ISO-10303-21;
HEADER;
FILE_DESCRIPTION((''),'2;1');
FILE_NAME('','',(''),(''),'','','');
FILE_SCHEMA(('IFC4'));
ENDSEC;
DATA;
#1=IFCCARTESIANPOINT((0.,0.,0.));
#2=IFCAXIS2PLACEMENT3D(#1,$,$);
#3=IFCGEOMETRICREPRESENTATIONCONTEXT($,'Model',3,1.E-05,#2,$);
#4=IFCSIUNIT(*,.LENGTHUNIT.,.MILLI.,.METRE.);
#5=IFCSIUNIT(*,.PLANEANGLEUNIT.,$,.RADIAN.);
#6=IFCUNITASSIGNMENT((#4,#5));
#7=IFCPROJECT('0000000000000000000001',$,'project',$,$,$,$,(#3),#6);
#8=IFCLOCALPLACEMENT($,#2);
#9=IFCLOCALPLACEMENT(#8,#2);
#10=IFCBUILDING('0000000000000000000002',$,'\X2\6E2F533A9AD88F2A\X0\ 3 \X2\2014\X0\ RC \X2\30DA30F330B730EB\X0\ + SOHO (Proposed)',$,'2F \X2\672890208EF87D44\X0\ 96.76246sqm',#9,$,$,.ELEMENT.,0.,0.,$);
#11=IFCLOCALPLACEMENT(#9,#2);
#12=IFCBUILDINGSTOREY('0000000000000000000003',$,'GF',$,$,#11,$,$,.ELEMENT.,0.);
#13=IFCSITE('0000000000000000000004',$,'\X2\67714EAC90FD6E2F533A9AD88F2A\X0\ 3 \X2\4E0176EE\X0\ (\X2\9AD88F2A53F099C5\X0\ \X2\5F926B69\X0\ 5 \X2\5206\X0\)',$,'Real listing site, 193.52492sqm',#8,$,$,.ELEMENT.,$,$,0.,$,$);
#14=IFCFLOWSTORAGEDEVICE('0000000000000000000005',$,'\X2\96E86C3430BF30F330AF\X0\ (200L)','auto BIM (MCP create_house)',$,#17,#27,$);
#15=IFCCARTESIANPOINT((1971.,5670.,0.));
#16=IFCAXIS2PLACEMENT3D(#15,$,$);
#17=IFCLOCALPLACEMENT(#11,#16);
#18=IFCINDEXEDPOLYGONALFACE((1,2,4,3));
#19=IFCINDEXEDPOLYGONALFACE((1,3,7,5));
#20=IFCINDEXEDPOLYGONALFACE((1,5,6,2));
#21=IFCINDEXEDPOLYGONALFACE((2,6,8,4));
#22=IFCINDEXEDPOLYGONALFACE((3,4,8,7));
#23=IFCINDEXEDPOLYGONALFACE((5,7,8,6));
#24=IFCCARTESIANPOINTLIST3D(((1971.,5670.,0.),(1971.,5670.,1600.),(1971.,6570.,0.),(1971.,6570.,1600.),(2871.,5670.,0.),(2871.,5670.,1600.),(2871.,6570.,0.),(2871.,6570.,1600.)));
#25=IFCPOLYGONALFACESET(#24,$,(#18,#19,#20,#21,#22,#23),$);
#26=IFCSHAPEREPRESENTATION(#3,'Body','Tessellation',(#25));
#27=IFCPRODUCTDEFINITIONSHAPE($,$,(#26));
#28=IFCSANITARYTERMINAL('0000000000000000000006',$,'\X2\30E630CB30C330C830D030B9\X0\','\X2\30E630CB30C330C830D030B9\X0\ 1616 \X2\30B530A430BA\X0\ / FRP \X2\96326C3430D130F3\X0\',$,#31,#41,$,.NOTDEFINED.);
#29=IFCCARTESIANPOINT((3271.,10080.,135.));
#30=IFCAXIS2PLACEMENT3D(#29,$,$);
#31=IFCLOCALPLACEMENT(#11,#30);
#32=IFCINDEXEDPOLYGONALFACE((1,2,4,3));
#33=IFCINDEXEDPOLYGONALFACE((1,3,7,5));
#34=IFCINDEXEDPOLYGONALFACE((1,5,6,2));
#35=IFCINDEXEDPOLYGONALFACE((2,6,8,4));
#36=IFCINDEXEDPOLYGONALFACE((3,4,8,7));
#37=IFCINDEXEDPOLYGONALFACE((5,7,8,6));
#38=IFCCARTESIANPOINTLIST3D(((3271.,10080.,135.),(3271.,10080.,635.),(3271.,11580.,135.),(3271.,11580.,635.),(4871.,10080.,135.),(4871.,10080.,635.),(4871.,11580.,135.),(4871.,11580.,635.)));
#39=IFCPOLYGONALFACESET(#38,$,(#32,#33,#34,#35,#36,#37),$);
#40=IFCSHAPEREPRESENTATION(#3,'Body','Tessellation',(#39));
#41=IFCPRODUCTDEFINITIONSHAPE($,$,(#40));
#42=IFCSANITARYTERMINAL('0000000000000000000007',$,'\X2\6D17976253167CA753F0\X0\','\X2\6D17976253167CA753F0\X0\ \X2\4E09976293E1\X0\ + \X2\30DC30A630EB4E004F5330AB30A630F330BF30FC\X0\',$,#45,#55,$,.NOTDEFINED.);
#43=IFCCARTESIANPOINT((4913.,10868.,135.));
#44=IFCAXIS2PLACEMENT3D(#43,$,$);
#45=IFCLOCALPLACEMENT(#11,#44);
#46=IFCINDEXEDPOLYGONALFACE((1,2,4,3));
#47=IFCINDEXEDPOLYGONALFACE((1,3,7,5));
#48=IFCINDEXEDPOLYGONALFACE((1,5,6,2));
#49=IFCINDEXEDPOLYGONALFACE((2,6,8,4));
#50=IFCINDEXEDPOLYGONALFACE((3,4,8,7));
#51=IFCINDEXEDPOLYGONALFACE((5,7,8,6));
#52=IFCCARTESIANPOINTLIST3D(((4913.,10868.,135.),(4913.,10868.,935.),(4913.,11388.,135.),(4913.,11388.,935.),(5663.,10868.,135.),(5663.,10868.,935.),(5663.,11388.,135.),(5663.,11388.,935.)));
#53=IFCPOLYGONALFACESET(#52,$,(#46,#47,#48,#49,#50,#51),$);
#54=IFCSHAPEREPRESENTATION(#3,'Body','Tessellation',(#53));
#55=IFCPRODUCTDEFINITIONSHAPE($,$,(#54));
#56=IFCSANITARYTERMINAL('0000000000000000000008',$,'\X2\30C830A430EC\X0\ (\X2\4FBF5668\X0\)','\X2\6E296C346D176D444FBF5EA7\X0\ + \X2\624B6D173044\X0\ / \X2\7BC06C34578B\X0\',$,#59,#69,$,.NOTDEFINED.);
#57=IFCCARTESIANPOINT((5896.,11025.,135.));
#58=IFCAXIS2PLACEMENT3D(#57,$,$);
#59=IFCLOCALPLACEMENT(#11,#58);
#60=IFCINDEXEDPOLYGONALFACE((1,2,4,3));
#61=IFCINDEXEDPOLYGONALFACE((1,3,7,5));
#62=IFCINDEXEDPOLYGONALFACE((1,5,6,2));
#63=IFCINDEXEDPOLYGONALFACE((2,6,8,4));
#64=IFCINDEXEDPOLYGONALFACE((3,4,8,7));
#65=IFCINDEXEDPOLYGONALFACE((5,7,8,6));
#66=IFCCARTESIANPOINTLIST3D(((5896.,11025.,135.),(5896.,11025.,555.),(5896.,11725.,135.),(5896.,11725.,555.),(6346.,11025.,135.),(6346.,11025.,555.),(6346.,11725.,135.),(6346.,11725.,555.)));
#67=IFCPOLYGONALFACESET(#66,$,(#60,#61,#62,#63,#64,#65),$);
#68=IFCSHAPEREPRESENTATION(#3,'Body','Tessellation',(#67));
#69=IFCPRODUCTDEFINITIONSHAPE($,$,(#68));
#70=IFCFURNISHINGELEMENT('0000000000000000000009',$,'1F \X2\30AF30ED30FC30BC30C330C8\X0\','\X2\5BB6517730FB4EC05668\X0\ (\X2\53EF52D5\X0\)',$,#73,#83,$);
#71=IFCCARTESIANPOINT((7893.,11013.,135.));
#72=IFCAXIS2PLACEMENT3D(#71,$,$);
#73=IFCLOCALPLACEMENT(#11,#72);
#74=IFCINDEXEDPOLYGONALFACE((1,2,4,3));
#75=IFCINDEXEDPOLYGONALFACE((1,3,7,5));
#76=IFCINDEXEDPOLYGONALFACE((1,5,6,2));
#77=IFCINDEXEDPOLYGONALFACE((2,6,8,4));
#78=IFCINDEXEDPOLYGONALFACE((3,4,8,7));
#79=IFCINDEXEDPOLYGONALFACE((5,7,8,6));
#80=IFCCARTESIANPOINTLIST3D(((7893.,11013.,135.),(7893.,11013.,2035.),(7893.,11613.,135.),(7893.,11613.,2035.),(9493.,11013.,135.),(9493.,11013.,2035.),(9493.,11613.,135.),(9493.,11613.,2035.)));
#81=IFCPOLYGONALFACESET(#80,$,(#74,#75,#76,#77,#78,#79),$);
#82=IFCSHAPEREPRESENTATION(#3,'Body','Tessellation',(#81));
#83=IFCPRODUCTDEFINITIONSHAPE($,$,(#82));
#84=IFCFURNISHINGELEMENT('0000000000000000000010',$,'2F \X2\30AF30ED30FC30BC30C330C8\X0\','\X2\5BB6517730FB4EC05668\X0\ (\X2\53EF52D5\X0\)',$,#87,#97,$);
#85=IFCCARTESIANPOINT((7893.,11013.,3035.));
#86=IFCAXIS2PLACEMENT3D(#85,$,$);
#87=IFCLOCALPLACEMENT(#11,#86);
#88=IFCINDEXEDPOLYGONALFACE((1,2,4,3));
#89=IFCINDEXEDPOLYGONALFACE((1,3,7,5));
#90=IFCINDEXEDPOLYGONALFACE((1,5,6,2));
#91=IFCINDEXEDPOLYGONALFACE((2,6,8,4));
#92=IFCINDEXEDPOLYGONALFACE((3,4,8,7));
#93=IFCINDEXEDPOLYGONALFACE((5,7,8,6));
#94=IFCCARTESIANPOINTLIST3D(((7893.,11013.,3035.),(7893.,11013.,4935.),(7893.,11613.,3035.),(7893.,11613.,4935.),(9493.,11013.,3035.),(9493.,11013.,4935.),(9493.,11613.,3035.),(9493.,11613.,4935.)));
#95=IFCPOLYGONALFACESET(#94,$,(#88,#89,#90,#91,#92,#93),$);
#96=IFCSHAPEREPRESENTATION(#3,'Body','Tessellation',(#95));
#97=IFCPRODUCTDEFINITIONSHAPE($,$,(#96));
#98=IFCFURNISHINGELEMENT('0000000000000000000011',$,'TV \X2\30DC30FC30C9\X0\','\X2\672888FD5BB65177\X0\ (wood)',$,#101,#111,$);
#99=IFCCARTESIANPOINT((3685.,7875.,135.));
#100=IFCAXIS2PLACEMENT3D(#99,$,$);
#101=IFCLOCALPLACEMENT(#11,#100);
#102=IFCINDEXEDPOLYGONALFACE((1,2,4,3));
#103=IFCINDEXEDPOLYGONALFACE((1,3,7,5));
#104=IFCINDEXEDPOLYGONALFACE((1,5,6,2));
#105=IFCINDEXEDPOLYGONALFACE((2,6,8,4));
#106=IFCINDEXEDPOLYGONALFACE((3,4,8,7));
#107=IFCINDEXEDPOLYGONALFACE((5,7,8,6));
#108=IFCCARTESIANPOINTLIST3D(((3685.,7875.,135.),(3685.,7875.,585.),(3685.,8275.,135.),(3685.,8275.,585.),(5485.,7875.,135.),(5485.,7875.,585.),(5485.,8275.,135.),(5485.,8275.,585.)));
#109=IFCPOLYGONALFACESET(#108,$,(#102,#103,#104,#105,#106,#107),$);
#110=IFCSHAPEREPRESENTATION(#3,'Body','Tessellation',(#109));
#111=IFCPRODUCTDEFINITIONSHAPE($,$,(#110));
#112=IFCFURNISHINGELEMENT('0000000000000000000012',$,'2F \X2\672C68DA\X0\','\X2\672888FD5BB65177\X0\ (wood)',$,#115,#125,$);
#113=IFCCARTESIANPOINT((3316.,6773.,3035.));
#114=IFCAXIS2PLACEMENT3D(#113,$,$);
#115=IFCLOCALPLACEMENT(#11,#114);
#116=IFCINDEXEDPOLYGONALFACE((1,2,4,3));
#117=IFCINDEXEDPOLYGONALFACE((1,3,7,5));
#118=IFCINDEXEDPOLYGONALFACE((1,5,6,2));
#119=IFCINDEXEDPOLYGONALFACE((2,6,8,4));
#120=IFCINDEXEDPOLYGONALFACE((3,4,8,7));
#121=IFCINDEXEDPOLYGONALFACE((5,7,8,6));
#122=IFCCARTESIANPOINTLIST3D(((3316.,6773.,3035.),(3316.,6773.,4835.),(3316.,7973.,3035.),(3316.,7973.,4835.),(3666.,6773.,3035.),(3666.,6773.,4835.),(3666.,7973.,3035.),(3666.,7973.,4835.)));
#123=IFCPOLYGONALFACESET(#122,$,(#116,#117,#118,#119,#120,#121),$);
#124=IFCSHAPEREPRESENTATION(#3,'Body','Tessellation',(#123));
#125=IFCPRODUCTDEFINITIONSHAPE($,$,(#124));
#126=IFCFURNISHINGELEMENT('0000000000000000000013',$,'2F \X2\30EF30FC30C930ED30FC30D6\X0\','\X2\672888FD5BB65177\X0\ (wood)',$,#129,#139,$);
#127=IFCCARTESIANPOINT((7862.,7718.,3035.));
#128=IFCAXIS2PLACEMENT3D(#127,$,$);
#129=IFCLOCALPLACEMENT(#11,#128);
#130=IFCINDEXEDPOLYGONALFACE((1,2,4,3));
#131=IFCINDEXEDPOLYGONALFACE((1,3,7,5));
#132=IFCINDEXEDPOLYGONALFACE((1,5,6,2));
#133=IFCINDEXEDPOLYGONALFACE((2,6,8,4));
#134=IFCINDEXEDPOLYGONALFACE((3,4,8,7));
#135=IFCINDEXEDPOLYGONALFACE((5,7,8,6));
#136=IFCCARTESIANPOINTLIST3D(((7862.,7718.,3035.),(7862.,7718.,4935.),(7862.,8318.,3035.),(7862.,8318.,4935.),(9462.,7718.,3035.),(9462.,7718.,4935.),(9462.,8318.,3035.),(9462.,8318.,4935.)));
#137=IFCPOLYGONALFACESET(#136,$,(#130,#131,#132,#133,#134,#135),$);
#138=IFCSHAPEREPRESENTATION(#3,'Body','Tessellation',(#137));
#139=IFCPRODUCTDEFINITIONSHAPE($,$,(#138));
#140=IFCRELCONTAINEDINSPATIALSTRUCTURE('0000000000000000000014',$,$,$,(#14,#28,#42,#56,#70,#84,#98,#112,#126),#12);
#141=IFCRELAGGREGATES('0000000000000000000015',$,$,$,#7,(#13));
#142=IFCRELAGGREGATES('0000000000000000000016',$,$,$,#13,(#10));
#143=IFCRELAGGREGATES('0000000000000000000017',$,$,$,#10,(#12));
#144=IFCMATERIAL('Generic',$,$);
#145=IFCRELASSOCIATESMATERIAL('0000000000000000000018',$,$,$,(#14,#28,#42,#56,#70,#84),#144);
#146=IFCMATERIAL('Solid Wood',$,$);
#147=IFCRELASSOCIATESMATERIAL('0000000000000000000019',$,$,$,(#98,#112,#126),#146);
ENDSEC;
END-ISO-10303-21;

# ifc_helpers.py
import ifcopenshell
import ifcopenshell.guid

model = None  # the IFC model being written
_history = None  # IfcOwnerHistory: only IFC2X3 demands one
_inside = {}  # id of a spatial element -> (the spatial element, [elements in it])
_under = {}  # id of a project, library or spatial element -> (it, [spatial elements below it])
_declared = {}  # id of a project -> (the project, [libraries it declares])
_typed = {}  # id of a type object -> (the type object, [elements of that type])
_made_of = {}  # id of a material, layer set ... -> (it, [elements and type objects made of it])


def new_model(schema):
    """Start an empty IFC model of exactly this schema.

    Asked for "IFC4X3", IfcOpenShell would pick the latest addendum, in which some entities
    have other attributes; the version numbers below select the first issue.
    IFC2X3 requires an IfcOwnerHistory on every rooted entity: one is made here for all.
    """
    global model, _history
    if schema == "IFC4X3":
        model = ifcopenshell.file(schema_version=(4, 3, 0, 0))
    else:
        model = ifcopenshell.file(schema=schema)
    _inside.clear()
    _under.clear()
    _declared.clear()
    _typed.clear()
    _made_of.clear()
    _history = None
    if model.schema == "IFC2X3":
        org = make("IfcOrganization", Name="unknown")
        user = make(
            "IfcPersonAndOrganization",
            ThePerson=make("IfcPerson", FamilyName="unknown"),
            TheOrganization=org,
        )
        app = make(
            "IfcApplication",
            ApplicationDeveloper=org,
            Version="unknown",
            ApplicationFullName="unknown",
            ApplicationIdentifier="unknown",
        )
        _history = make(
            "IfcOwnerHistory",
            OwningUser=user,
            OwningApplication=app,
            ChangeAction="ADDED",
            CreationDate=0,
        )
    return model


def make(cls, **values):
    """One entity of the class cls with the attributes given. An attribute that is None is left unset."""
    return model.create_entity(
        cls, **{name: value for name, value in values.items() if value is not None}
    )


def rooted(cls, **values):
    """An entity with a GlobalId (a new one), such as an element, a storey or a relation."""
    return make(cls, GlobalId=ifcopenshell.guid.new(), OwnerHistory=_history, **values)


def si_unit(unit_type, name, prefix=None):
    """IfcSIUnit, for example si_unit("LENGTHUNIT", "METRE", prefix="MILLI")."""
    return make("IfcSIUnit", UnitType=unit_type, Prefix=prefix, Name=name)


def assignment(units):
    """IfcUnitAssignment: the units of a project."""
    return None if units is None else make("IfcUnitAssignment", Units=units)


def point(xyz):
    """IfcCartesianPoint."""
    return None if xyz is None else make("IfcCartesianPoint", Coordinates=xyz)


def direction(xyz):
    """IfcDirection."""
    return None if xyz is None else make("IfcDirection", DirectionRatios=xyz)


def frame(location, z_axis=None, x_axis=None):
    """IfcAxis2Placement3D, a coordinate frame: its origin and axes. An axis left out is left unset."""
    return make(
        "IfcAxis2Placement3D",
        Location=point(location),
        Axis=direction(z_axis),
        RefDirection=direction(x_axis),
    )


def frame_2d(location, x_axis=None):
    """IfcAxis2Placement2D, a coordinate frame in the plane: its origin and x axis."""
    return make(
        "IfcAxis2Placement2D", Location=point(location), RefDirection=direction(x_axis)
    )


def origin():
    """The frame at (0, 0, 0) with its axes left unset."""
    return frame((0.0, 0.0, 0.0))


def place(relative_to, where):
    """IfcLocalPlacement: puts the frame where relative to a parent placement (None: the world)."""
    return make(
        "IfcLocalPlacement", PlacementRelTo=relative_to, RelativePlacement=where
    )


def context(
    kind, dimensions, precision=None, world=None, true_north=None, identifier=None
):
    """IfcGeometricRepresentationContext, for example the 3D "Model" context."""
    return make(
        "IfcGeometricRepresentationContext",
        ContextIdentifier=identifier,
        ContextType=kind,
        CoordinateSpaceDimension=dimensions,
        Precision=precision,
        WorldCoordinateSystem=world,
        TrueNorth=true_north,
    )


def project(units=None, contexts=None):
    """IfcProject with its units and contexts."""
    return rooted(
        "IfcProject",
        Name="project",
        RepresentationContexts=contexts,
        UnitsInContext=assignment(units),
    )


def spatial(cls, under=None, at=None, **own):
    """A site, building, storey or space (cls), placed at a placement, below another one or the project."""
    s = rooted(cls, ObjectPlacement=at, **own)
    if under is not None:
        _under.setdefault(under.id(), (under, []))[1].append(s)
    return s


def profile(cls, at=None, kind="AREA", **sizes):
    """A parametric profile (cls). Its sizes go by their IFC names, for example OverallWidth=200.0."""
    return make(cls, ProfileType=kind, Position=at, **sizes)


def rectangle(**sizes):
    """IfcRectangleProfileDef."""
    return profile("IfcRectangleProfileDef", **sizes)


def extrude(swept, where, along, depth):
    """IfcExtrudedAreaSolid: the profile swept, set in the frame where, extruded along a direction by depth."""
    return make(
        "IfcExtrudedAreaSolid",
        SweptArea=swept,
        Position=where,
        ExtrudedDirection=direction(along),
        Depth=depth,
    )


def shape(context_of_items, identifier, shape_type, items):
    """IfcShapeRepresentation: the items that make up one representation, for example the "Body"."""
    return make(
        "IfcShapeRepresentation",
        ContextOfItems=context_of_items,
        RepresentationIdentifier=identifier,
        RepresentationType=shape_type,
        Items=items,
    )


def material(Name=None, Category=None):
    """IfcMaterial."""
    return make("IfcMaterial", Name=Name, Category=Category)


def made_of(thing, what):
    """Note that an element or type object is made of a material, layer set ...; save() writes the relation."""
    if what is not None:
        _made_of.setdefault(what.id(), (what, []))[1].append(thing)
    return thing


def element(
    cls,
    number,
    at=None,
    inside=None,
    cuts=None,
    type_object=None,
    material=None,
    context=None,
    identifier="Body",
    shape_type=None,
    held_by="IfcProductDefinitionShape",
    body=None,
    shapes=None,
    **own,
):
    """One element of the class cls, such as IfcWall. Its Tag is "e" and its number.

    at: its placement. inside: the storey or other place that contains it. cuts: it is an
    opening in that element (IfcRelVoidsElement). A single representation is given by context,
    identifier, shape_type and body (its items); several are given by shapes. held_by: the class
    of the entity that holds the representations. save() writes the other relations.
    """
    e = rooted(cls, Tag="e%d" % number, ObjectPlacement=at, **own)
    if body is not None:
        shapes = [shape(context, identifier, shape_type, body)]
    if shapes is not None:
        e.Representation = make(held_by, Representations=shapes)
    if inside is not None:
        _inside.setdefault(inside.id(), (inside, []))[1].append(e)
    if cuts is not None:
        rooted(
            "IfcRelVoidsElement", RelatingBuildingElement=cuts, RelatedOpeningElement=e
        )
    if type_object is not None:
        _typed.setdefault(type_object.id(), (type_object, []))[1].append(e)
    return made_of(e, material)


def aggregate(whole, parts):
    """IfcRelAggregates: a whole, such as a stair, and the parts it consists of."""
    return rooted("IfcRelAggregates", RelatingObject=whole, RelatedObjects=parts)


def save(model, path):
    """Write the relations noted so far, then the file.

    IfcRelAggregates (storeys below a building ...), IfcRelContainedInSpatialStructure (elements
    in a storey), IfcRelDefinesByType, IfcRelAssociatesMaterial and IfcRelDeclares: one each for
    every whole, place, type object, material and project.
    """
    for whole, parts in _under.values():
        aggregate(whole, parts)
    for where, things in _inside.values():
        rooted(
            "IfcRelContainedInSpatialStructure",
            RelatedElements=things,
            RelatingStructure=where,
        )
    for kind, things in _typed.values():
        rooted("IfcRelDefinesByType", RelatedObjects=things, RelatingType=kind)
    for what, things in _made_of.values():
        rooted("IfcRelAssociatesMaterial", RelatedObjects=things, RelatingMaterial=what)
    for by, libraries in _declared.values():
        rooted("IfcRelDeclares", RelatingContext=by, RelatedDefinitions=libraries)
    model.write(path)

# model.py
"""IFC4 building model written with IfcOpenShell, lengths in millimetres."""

from ifc_helpers import new_model, si_unit, frame, frame_2d, origin, place, context, project, spatial, rectangle, extrude, material, element, save


model = new_model("IFC4")

# Units and contexts
model_context = context("Model", 3, precision=1e-05, world=origin())
ifc_project = project(units=[si_unit("LENGTHUNIT", "METRE", prefix="MILLI"), si_unit("PLANEANGLEUNIT", "RADIAN")], contexts=[model_context])

# Site, building, storey
site_placement = place(None, origin())
site = spatial("IfcSite", under=ifc_project, at=site_placement, Name="東京都港区高輪 3 丁目 (高輪台駅 徒歩 5 分)", ObjectType="Real listing site, 193.52492sqm", CompositionType="ELEMENT", RefElevation=0.0)
building_placement = place(site_placement, origin())
building = spatial("IfcBuilding", under=site, at=building_placement, Name="港区高輪 3 — RC ペンシル + SOHO (Proposed)", ObjectType="2F 木造軸組 96.76246sqm", CompositionType="ELEMENT", ElevationOfRefHeight=0.0, ElevationOfTerrain=0.0)
storey_placement = place(building_placement, origin())
storey = spatial("IfcBuildingStorey", under=building, at=storey_placement, Name="GF", CompositionType="ELEMENT", Elevation=0.0)

# Shared definitions
ifc_material_1 = material(Name="Solid Wood")

# Flow storage device
ifc_material_2 = material(Name="Generic")
flow_storage_device_placement = place(storey_placement, frame((1971.0, 5670.0, 0.0)))
element("IfcFlowStorageDevice", 1, at=flow_storage_device_placement, inside=storey, material=ifc_material_2, Name="雨水タンク (200L)", Description="auto BIM (MCP create_house)", context=model_context, shape_type="SweptSolid", body=[
    extrude(rectangle(XDim=900.0, YDim=900.0, at=frame_2d((450.0, 450.0))), frame((1971.0, 5670.0, 0.0)), (0.0, 0.0, 1.0), 1600.0),
])

# Sanitary terminals
sanitary_terminal_1_placement = place(storey_placement, frame((3271.0, 10080.0, 135.0)))
element("IfcSanitaryTerminal", 2, at=sanitary_terminal_1_placement, inside=storey, material=ifc_material_2, Name="ユニットバス", Description="ユニットバス 1616 サイズ / FRP 防水パン", PredefinedType="NOTDEFINED", context=model_context, shape_type="SweptSolid", body=[
    extrude(rectangle(XDim=1600.0, YDim=1500.0, at=frame_2d((800.0, 750.0))), frame((3271.0, 10080.0, 135.0)), (0.0, 0.0, 1.0), 500.0),
])
sanitary_terminal_2_placement = place(storey_placement, frame((4913.0, 10868.0, 135.0)))
element("IfcSanitaryTerminal", 3, at=sanitary_terminal_2_placement, inside=storey, material=ifc_material_2, Name="洗面化粧台", Description="洗面化粧台 三面鏡 + ボウル一体カウンター", PredefinedType="NOTDEFINED", context=model_context, shape_type="SweptSolid", body=[
    extrude(rectangle(XDim=750.0, YDim=520.0, at=frame_2d((375.0, 260.0))), frame((4913.0, 10868.0, 135.0)), (0.0, 0.0, 1.0), 800.0),
])
sanitary_terminal_3_placement = place(storey_placement, frame((5896.0, 11025.0, 135.0)))
element("IfcSanitaryTerminal", 4, at=sanitary_terminal_3_placement, inside=storey, material=ifc_material_2, Name="トイレ (便器)", Description="温水洗浄便座 + 手洗い / 節水型", PredefinedType="NOTDEFINED", context=model_context, shape_type="SweptSolid", body=[
    extrude(rectangle(XDim=450.0, YDim=700.0, at=frame_2d((225.0, 350.0))), frame((5896.0, 11025.0, 135.0)), (0.0, 0.0, 1.0), 420.0),
])

# Furnishing elements
furnishing_1_placement = place(storey_placement, frame((7893.0, 11013.0, 135.0)))
element("IfcFurnishingElement", 5, at=furnishing_1_placement, inside=storey, material=ifc_material_2, Name="1F クローゼット", Description="家具・什器 (可動)", context=model_context, shape_type="SweptSolid", body=[
    extrude(rectangle(XDim=1600.0, YDim=600.0, at=frame_2d((800.0, 300.0))), frame((7893.0, 11013.0, 135.0)), (0.0, 0.0, 1.0), 1900.0),
])
furnishing_2_placement = place(storey_placement, frame((7893.0, 11013.0, 3035.0)))
element("IfcFurnishingElement", 6, at=furnishing_2_placement, inside=storey, material=ifc_material_2, Name="2F クローゼット", Description="家具・什器 (可動)", context=model_context, shape_type="SweptSolid", body=[
    extrude(rectangle(XDim=1600.0, YDim=600.0, at=frame_2d((800.0, 300.0))), frame((7893.0, 11013.0, 3035.0)), (0.0, 0.0, 1.0), 1900.0),
])
furnishing_3_placement = place(storey_placement, frame((3685.0, 7875.0, 135.0)))
element("IfcFurnishingElement", 7, at=furnishing_3_placement, inside=storey, material=ifc_material_1, Name="TV ボード", Description="木製家具 (wood)", context=model_context, shape_type="SweptSolid", body=[
    extrude(rectangle(XDim=1800.0, YDim=400.0, at=frame_2d((900.0, 200.0))), frame((3685.0, 7875.0, 135.0)), (0.0, 0.0, 1.0), 450.0),
])
furnishing_4_placement = place(storey_placement, frame((3316.0, 6773.0, 3035.0)))
element("IfcFurnishingElement", 8, at=furnishing_4_placement, inside=storey, material=ifc_material_1, Name="2F 本棚", Description="木製家具 (wood)", context=model_context, shape_type="SweptSolid", body=[
    extrude(rectangle(XDim=350.0, YDim=1200.0, at=frame_2d((175.0, 600.0))), frame((3316.0, 6773.0, 3035.0)), (0.0, 0.0, 1.0), 1800.0),
])
furnishing_5_placement = place(storey_placement, frame((7862.0, 7718.0, 3035.0)))
element("IfcFurnishingElement", 9, at=furnishing_5_placement, inside=storey, material=ifc_material_1, Name="2F ワードローブ", Description="木製家具 (wood)", context=model_context, shape_type="SweptSolid", body=[
    extrude(rectangle(XDim=1600.0, YDim=600.0, at=frame_2d((800.0, 300.0))), frame((7862.0, 7718.0, 3035.0)), (0.0, 0.0, 1.0), 1900.0),
])

save(model, "model.ifc")
